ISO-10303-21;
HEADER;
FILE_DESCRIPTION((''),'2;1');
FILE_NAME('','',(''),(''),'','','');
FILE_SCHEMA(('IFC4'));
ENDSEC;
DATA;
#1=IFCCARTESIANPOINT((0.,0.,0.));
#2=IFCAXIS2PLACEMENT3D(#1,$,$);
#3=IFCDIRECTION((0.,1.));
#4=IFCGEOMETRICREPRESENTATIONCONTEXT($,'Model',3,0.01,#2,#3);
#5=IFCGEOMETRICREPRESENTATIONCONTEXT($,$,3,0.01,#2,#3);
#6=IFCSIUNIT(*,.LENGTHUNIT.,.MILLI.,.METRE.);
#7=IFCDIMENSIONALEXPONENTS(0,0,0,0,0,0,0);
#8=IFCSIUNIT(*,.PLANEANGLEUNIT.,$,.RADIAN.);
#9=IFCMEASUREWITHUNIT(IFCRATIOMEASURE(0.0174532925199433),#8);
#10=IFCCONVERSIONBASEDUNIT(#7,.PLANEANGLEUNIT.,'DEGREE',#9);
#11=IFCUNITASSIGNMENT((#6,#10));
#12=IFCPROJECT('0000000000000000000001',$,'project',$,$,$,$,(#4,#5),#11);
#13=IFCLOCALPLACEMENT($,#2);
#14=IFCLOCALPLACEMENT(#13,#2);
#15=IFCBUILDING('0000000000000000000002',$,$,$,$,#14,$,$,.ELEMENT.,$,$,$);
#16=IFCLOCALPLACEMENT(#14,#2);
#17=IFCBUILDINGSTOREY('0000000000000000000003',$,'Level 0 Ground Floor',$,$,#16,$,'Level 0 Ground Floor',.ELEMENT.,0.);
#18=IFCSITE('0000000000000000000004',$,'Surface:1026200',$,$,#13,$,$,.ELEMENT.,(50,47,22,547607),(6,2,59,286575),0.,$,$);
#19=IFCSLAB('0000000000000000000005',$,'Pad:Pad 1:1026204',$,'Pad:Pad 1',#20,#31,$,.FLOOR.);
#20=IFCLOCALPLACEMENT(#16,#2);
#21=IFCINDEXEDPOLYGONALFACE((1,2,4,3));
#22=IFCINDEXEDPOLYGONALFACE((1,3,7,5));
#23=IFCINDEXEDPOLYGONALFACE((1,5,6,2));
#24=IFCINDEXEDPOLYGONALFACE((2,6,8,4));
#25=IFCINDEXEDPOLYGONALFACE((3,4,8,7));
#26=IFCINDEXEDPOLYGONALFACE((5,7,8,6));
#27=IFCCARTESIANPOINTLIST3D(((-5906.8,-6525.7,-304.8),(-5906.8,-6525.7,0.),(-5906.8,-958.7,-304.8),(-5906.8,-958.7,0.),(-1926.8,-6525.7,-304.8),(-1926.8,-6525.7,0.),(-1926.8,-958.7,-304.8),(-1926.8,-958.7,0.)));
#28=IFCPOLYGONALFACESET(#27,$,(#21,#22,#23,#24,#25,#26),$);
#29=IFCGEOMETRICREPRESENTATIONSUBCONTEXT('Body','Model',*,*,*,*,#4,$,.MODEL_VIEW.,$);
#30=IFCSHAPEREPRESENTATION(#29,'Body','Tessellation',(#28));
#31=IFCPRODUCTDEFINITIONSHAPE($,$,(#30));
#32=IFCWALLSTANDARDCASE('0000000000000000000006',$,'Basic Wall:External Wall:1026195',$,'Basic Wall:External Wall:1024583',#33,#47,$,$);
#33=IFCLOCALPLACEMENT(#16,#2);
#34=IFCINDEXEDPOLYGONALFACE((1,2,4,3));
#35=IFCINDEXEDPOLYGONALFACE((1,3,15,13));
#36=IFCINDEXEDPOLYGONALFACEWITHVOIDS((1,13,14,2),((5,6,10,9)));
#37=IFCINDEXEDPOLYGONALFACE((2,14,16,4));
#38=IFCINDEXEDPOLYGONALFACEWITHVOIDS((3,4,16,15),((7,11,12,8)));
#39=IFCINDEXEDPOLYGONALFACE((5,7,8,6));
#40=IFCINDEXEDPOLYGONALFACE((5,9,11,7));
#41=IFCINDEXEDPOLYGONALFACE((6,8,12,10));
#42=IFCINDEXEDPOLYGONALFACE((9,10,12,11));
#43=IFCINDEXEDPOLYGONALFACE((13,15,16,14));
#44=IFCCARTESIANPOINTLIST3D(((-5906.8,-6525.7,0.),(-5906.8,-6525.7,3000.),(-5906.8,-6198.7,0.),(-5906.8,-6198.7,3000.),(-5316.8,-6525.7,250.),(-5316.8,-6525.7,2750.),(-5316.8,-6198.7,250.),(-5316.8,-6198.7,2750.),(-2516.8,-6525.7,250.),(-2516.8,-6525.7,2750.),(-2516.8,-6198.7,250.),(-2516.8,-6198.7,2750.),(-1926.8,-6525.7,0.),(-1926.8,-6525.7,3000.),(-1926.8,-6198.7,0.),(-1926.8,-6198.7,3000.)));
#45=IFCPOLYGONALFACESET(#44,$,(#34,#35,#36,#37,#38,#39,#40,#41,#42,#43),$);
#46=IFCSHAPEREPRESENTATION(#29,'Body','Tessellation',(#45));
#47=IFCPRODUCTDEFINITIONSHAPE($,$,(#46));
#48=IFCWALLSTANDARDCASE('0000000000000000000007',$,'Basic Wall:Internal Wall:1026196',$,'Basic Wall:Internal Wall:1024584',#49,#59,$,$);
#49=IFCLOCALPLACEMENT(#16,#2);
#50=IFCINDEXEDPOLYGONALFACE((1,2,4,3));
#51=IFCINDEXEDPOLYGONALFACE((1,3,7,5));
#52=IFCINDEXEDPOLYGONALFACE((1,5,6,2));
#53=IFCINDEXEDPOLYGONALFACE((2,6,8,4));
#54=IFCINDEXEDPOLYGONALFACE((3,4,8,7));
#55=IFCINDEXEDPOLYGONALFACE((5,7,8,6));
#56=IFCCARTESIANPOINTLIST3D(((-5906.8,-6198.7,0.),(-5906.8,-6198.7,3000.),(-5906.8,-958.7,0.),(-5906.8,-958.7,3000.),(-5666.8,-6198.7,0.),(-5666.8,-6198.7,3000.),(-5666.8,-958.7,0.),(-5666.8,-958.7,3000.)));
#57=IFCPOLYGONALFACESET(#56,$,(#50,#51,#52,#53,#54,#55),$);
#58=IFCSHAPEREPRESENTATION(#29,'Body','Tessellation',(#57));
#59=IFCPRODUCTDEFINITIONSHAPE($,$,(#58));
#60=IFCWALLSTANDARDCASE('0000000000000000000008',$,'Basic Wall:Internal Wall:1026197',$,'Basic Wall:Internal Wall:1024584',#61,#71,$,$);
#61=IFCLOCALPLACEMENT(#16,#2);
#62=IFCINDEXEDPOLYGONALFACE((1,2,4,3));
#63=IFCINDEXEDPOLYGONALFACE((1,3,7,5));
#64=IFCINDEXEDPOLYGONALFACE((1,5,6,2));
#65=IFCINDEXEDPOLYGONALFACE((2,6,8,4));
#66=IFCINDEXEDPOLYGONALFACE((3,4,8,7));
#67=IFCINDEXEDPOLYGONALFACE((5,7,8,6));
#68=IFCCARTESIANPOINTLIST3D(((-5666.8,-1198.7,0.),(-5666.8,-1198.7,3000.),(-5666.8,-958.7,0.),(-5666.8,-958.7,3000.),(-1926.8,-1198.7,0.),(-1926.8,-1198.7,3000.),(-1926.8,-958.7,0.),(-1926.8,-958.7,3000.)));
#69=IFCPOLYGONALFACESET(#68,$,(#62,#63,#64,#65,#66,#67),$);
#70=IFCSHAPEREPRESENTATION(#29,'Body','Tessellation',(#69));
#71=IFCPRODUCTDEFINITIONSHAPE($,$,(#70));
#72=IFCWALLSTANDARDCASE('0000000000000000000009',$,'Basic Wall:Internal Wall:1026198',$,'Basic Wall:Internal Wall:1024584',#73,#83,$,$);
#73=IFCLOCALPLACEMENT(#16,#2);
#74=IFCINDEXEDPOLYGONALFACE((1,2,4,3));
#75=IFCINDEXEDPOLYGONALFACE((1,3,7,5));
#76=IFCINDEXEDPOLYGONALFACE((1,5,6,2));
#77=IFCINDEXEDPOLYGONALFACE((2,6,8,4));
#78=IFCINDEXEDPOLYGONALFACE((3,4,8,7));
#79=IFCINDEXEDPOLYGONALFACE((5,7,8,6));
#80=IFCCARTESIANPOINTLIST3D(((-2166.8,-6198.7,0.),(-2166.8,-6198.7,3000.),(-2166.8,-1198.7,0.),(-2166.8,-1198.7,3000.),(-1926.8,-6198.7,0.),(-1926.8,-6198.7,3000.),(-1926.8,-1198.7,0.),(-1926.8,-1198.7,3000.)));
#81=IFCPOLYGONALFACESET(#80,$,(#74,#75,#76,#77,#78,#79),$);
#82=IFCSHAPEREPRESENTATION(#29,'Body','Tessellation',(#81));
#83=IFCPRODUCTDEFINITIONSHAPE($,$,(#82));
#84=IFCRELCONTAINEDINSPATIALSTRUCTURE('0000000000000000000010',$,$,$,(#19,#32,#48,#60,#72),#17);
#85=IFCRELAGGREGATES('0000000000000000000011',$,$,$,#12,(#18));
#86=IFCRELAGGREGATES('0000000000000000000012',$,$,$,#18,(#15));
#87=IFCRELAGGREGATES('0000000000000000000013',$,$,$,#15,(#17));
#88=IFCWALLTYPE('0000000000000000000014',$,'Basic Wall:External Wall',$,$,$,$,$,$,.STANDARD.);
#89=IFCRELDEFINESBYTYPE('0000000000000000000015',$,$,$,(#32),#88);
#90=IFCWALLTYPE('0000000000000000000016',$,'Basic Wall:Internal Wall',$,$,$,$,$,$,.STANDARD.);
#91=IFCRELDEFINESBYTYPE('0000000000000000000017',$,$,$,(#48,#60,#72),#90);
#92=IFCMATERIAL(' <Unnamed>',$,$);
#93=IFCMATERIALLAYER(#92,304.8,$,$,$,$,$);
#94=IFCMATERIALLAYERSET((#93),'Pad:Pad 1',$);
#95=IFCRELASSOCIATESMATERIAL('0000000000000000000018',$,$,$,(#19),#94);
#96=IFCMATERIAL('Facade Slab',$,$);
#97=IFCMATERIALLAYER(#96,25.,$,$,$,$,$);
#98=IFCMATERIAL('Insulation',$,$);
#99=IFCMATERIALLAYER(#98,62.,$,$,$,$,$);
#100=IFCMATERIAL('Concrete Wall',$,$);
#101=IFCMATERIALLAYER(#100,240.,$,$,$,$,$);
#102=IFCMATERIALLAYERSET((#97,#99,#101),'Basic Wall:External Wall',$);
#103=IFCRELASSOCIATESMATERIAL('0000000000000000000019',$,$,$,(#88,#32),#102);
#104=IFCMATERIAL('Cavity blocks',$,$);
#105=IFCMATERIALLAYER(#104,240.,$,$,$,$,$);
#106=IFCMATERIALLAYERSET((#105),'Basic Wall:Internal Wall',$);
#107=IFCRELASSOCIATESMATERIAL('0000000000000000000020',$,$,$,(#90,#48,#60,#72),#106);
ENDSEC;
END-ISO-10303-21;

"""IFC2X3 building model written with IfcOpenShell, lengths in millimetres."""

from ifc_helpers import new_model, entity, si_unit, converted_unit, direction, frame, frame_2d, origin, place, context, subcontext, project, spatial, polyline, rectangle, extrude, clip, bounded_halfspace, material, layer, layer_set, layer_usage, type_object, element, save


model = new_model("IFC2X3")

# Units and contexts
model_context = context("Model", 3, precision=0.01, world=origin(), true_north=direction((0.0, 1.0)))
context_of_model = context(None, 3, precision=0.01, world=origin(), true_north=direction((0.0, 1.0)))
body_context = subcontext(model_context, "Body", "Model", "MODEL_VIEW")
ifc_project = project(units=[si_unit("LENGTHUNIT", "METRE", prefix="MILLI"), converted_unit("PLANEANGLEUNIT", "DEGREE", entity("IfcRatioMeasure", 0.0174532925199433), si_unit("PLANEANGLEUNIT", "RADIAN"), dimensions=[0, 0, 0, 0, 0, 0, 0])], contexts=[model_context, context_of_model])

# Site, building, storey
site_placement = place(None, origin())
site = spatial("IfcSite", under=ifc_project, at=site_placement, Name="Surface:1026200", CompositionType="ELEMENT", RefLatitude=(50, 47, 22, 547607), RefLongitude=(6, 2, 59, 286575), RefElevation=0.0)
building_placement = place(site_placement, origin())
building = spatial("IfcBuilding", under=site, at=building_placement, CompositionType="ELEMENT")
storey_placement = place(building_placement, origin())
storey = spatial("IfcBuildingStorey", under=building, at=storey_placement, Name="Level 0 Ground Floor", LongName="Level 0 Ground Floor", CompositionType="ELEMENT", Elevation=0.0)

# Slab
ifc_material_1 = material(Name=" <Unnamed>")
ifc_layer_1 = layer(ifc_material_1, 304.8)
ifc_layer_set_1 = layer_set([ifc_layer_1], Name="Pad:Pad 1")
ifc_layer_usage_1 = layer_usage(ifc_layer_set_1, "AXIS3", "NEGATIVE", 0.0)
slab_placement = place(storey_placement, origin())
element("IfcSlab", 1, at=slab_placement, inside=storey, material=ifc_layer_usage_1, Name="Pad:Pad 1:1026204", ObjectType="Pad:Pad 1", PredefinedType="FLOOR", context=body_context, shape_type="SweptSolid", body=[
    extrude(rectangle(XDim=3980.0, YDim=5567.0, at=frame_2d((0.0, 0.0), x_axis=(1.0, 0.0))), frame((-3916.8, -3742.2, -304.8), z_axis=(0.0, 0.0, 1.0), x_axis=(-1.0, 0.0, 0.0)), (0.0, 0.0, 1.0), 304.8),
])

# Wall, opening
ifc_material_2 = material(Name="Facade Slab")
ifc_layer_2 = layer(ifc_material_2, 25.0)
ifc_material_3 = material(Name="Insulation")
ifc_layer_3 = layer(ifc_material_3, 62.0)
ifc_material_4 = material(Name="Concrete Wall")
ifc_layer_4 = layer(ifc_material_4, 240.0)
ifc_layer_set_2 = layer_set([ifc_layer_2, ifc_layer_3, ifc_layer_4], Name="Basic Wall:External Wall")
ifc_layer_usage_2 = layer_usage(ifc_layer_set_2, "AXIS2", "POSITIVE", -163.5)
wall_type_1 = type_object("IfcWallType", Name="Basic Wall:External Wall", PredefinedType="STANDARD", material=ifc_layer_set_2)
wall_1_placement = place(storey_placement, frame((-5906.8, -6362.2, 0.0)))
wall_1 = element("IfcWallStandardCase", 2, at=wall_1_placement, inside=storey, type_object=wall_type_1, material=ifc_layer_usage_2, Name="Basic Wall:External Wall:1026195", ObjectType="Basic Wall:External Wall:1024583", context=body_context, shape_type="Clipping", body=[
    clip(extrude(rectangle(XDim=3980.0, YDim=327.0, at=frame_2d((1990.0, 0.0), x_axis=(-1.0, 0.0))), origin(), (0.0, 0.0, 1.0), 3000.0), bounded_halfspace(frame((0.0, -163.5, 3000.0), z_axis=(0.0, 0.0, -1.0), x_axis=(0.0, -1.0, 0.0)), True, frame((0.0, -163.5, 3000.0)), polyline([(0.0, 0.0), (3980.0, 0.0), (3980.0, 327.0), (3740.0, 327.0), (240.0, 327.0), (0.0, 327.0), (0.0, 0.0)]))),
])
opening_placement = place(wall_1_placement, frame((590.0, -163.5, 250.0)))
element("IfcOpeningElement", 3, at=opening_placement, cuts=wall_1, ObjectType="Opening", context=body_context, shape_type="SweptSolid", body=[
    extrude(rectangle(XDim=2500.0, YDim=2800.0, at=frame_2d((1250.0, 1400.0), x_axis=(1.0, 0.0))), frame((0.0, 0.0, 0.0), z_axis=(0.0, 1.0, 0.0), x_axis=(0.0, 0.0, 1.0)), (0.0, 0.0, 1.0), 327.0),
])

# Walls
ifc_material_5 = material(Name="Cavity blocks")
ifc_layer_5 = layer(ifc_material_5, 240.0)
ifc_layer_set_3 = layer_set([ifc_layer_5], Name="Basic Wall:Internal Wall")
ifc_layer_usage_3 = layer_usage(ifc_layer_set_3, "AXIS2", "NEGATIVE", 120.0)
wall_type_2 = type_object("IfcWallType", Name="Basic Wall:Internal Wall", PredefinedType="STANDARD", material=ifc_layer_set_3)
wall_2_placement = place(storey_placement, frame((-5786.8, -6198.7, 0.0), z_axis=(0.0, 0.0, 1.0), x_axis=(0.0, 1.0, 0.0)))
element("IfcWallStandardCase", 4, at=wall_2_placement, inside=storey, type_object=wall_type_2, material=ifc_layer_usage_3, Name="Basic Wall:Internal Wall:1026196", ObjectType="Basic Wall:Internal Wall:1024584", context=body_context, shape_type="Clipping", body=[
    clip(extrude(rectangle(XDim=5240.0, YDim=240.0, at=frame_2d((2620.0, 0.0), x_axis=(-1.0, 0.0))), origin(), (0.0, 0.0, 1.0), 3000.0), bounded_halfspace(frame((0.0, -120.0, 3000.0), z_axis=(0.0, 0.0, -1.0), x_axis=(-1.0, 0.0, 0.0)), True, frame((0.0, -120.0, 3000.0)), polyline([(0.0, 0.0), (5000.0, 0.0), (5240.0, 0.0), (5240.0, 240.0), (0.0, 240.0), (0.0, 0.0)]))),
])
ifc_layer_usage_4 = layer_usage(ifc_layer_set_3, "AXIS2", "NEGATIVE", 120.0)
wall_3_placement = place(storey_placement, frame((-5666.8, -1078.7, 0.0)))
element("IfcWallStandardCase", 5, at=wall_3_placement, inside=storey, type_object=wall_type_2, material=ifc_layer_usage_4, Name="Basic Wall:Internal Wall:1026197", ObjectType="Basic Wall:Internal Wall:1024584", context=body_context, shape_type="Clipping", body=[
    clip(extrude(rectangle(XDim=3740.0, YDim=240.0, at=frame_2d((1870.0, 0.0), x_axis=(-1.0, 0.0))), origin(), (0.0, 0.0, 1.0), 3000.0), bounded_halfspace(frame((0.0, -120.0, 3000.0), z_axis=(0.0, 0.0, -1.0), x_axis=(0.0, -1.0, 0.0)), True, frame((0.0, -120.0, 3000.0)), polyline([(0.0, 0.0), (3500.0, 0.0), (3740.0, 0.0), (3740.0, 240.0), (0.0, 240.0), (0.0, 0.0)]))),
])
ifc_layer_usage_5 = layer_usage(ifc_layer_set_3, "AXIS2", "NEGATIVE", 120.0)
wall_4_placement = place(storey_placement, frame((-2046.8, -1198.7, 0.0), z_axis=(0.0, 0.0, 1.0), x_axis=(0.0, -1.0, 0.0)))
element("IfcWallStandardCase", 6, at=wall_4_placement, inside=storey, type_object=wall_type_2, material=ifc_layer_usage_5, Name="Basic Wall:Internal Wall:1026198", ObjectType="Basic Wall:Internal Wall:1024584", context=body_context, shape_type="Clipping", body=[
    clip(extrude(rectangle(XDim=5000.0, YDim=240.0, at=frame_2d((2500.0, 0.0), x_axis=(-1.0, 0.0))), origin(), (0.0, 0.0, 1.0), 3000.0), bounded_halfspace(frame((0.0, -120.0, 3000.0), z_axis=(0.0, 0.0, -1.0), x_axis=(1.0, 0.0, 0.0)), True, frame((0.0, -120.0, 3000.0)), polyline([(0.0, 0.0), (5000.0, 0.0), (5000.0, 240.0), (0.0, 240.0), (0.0, 0.0)]))),
])

save(model, "model.ifc")
